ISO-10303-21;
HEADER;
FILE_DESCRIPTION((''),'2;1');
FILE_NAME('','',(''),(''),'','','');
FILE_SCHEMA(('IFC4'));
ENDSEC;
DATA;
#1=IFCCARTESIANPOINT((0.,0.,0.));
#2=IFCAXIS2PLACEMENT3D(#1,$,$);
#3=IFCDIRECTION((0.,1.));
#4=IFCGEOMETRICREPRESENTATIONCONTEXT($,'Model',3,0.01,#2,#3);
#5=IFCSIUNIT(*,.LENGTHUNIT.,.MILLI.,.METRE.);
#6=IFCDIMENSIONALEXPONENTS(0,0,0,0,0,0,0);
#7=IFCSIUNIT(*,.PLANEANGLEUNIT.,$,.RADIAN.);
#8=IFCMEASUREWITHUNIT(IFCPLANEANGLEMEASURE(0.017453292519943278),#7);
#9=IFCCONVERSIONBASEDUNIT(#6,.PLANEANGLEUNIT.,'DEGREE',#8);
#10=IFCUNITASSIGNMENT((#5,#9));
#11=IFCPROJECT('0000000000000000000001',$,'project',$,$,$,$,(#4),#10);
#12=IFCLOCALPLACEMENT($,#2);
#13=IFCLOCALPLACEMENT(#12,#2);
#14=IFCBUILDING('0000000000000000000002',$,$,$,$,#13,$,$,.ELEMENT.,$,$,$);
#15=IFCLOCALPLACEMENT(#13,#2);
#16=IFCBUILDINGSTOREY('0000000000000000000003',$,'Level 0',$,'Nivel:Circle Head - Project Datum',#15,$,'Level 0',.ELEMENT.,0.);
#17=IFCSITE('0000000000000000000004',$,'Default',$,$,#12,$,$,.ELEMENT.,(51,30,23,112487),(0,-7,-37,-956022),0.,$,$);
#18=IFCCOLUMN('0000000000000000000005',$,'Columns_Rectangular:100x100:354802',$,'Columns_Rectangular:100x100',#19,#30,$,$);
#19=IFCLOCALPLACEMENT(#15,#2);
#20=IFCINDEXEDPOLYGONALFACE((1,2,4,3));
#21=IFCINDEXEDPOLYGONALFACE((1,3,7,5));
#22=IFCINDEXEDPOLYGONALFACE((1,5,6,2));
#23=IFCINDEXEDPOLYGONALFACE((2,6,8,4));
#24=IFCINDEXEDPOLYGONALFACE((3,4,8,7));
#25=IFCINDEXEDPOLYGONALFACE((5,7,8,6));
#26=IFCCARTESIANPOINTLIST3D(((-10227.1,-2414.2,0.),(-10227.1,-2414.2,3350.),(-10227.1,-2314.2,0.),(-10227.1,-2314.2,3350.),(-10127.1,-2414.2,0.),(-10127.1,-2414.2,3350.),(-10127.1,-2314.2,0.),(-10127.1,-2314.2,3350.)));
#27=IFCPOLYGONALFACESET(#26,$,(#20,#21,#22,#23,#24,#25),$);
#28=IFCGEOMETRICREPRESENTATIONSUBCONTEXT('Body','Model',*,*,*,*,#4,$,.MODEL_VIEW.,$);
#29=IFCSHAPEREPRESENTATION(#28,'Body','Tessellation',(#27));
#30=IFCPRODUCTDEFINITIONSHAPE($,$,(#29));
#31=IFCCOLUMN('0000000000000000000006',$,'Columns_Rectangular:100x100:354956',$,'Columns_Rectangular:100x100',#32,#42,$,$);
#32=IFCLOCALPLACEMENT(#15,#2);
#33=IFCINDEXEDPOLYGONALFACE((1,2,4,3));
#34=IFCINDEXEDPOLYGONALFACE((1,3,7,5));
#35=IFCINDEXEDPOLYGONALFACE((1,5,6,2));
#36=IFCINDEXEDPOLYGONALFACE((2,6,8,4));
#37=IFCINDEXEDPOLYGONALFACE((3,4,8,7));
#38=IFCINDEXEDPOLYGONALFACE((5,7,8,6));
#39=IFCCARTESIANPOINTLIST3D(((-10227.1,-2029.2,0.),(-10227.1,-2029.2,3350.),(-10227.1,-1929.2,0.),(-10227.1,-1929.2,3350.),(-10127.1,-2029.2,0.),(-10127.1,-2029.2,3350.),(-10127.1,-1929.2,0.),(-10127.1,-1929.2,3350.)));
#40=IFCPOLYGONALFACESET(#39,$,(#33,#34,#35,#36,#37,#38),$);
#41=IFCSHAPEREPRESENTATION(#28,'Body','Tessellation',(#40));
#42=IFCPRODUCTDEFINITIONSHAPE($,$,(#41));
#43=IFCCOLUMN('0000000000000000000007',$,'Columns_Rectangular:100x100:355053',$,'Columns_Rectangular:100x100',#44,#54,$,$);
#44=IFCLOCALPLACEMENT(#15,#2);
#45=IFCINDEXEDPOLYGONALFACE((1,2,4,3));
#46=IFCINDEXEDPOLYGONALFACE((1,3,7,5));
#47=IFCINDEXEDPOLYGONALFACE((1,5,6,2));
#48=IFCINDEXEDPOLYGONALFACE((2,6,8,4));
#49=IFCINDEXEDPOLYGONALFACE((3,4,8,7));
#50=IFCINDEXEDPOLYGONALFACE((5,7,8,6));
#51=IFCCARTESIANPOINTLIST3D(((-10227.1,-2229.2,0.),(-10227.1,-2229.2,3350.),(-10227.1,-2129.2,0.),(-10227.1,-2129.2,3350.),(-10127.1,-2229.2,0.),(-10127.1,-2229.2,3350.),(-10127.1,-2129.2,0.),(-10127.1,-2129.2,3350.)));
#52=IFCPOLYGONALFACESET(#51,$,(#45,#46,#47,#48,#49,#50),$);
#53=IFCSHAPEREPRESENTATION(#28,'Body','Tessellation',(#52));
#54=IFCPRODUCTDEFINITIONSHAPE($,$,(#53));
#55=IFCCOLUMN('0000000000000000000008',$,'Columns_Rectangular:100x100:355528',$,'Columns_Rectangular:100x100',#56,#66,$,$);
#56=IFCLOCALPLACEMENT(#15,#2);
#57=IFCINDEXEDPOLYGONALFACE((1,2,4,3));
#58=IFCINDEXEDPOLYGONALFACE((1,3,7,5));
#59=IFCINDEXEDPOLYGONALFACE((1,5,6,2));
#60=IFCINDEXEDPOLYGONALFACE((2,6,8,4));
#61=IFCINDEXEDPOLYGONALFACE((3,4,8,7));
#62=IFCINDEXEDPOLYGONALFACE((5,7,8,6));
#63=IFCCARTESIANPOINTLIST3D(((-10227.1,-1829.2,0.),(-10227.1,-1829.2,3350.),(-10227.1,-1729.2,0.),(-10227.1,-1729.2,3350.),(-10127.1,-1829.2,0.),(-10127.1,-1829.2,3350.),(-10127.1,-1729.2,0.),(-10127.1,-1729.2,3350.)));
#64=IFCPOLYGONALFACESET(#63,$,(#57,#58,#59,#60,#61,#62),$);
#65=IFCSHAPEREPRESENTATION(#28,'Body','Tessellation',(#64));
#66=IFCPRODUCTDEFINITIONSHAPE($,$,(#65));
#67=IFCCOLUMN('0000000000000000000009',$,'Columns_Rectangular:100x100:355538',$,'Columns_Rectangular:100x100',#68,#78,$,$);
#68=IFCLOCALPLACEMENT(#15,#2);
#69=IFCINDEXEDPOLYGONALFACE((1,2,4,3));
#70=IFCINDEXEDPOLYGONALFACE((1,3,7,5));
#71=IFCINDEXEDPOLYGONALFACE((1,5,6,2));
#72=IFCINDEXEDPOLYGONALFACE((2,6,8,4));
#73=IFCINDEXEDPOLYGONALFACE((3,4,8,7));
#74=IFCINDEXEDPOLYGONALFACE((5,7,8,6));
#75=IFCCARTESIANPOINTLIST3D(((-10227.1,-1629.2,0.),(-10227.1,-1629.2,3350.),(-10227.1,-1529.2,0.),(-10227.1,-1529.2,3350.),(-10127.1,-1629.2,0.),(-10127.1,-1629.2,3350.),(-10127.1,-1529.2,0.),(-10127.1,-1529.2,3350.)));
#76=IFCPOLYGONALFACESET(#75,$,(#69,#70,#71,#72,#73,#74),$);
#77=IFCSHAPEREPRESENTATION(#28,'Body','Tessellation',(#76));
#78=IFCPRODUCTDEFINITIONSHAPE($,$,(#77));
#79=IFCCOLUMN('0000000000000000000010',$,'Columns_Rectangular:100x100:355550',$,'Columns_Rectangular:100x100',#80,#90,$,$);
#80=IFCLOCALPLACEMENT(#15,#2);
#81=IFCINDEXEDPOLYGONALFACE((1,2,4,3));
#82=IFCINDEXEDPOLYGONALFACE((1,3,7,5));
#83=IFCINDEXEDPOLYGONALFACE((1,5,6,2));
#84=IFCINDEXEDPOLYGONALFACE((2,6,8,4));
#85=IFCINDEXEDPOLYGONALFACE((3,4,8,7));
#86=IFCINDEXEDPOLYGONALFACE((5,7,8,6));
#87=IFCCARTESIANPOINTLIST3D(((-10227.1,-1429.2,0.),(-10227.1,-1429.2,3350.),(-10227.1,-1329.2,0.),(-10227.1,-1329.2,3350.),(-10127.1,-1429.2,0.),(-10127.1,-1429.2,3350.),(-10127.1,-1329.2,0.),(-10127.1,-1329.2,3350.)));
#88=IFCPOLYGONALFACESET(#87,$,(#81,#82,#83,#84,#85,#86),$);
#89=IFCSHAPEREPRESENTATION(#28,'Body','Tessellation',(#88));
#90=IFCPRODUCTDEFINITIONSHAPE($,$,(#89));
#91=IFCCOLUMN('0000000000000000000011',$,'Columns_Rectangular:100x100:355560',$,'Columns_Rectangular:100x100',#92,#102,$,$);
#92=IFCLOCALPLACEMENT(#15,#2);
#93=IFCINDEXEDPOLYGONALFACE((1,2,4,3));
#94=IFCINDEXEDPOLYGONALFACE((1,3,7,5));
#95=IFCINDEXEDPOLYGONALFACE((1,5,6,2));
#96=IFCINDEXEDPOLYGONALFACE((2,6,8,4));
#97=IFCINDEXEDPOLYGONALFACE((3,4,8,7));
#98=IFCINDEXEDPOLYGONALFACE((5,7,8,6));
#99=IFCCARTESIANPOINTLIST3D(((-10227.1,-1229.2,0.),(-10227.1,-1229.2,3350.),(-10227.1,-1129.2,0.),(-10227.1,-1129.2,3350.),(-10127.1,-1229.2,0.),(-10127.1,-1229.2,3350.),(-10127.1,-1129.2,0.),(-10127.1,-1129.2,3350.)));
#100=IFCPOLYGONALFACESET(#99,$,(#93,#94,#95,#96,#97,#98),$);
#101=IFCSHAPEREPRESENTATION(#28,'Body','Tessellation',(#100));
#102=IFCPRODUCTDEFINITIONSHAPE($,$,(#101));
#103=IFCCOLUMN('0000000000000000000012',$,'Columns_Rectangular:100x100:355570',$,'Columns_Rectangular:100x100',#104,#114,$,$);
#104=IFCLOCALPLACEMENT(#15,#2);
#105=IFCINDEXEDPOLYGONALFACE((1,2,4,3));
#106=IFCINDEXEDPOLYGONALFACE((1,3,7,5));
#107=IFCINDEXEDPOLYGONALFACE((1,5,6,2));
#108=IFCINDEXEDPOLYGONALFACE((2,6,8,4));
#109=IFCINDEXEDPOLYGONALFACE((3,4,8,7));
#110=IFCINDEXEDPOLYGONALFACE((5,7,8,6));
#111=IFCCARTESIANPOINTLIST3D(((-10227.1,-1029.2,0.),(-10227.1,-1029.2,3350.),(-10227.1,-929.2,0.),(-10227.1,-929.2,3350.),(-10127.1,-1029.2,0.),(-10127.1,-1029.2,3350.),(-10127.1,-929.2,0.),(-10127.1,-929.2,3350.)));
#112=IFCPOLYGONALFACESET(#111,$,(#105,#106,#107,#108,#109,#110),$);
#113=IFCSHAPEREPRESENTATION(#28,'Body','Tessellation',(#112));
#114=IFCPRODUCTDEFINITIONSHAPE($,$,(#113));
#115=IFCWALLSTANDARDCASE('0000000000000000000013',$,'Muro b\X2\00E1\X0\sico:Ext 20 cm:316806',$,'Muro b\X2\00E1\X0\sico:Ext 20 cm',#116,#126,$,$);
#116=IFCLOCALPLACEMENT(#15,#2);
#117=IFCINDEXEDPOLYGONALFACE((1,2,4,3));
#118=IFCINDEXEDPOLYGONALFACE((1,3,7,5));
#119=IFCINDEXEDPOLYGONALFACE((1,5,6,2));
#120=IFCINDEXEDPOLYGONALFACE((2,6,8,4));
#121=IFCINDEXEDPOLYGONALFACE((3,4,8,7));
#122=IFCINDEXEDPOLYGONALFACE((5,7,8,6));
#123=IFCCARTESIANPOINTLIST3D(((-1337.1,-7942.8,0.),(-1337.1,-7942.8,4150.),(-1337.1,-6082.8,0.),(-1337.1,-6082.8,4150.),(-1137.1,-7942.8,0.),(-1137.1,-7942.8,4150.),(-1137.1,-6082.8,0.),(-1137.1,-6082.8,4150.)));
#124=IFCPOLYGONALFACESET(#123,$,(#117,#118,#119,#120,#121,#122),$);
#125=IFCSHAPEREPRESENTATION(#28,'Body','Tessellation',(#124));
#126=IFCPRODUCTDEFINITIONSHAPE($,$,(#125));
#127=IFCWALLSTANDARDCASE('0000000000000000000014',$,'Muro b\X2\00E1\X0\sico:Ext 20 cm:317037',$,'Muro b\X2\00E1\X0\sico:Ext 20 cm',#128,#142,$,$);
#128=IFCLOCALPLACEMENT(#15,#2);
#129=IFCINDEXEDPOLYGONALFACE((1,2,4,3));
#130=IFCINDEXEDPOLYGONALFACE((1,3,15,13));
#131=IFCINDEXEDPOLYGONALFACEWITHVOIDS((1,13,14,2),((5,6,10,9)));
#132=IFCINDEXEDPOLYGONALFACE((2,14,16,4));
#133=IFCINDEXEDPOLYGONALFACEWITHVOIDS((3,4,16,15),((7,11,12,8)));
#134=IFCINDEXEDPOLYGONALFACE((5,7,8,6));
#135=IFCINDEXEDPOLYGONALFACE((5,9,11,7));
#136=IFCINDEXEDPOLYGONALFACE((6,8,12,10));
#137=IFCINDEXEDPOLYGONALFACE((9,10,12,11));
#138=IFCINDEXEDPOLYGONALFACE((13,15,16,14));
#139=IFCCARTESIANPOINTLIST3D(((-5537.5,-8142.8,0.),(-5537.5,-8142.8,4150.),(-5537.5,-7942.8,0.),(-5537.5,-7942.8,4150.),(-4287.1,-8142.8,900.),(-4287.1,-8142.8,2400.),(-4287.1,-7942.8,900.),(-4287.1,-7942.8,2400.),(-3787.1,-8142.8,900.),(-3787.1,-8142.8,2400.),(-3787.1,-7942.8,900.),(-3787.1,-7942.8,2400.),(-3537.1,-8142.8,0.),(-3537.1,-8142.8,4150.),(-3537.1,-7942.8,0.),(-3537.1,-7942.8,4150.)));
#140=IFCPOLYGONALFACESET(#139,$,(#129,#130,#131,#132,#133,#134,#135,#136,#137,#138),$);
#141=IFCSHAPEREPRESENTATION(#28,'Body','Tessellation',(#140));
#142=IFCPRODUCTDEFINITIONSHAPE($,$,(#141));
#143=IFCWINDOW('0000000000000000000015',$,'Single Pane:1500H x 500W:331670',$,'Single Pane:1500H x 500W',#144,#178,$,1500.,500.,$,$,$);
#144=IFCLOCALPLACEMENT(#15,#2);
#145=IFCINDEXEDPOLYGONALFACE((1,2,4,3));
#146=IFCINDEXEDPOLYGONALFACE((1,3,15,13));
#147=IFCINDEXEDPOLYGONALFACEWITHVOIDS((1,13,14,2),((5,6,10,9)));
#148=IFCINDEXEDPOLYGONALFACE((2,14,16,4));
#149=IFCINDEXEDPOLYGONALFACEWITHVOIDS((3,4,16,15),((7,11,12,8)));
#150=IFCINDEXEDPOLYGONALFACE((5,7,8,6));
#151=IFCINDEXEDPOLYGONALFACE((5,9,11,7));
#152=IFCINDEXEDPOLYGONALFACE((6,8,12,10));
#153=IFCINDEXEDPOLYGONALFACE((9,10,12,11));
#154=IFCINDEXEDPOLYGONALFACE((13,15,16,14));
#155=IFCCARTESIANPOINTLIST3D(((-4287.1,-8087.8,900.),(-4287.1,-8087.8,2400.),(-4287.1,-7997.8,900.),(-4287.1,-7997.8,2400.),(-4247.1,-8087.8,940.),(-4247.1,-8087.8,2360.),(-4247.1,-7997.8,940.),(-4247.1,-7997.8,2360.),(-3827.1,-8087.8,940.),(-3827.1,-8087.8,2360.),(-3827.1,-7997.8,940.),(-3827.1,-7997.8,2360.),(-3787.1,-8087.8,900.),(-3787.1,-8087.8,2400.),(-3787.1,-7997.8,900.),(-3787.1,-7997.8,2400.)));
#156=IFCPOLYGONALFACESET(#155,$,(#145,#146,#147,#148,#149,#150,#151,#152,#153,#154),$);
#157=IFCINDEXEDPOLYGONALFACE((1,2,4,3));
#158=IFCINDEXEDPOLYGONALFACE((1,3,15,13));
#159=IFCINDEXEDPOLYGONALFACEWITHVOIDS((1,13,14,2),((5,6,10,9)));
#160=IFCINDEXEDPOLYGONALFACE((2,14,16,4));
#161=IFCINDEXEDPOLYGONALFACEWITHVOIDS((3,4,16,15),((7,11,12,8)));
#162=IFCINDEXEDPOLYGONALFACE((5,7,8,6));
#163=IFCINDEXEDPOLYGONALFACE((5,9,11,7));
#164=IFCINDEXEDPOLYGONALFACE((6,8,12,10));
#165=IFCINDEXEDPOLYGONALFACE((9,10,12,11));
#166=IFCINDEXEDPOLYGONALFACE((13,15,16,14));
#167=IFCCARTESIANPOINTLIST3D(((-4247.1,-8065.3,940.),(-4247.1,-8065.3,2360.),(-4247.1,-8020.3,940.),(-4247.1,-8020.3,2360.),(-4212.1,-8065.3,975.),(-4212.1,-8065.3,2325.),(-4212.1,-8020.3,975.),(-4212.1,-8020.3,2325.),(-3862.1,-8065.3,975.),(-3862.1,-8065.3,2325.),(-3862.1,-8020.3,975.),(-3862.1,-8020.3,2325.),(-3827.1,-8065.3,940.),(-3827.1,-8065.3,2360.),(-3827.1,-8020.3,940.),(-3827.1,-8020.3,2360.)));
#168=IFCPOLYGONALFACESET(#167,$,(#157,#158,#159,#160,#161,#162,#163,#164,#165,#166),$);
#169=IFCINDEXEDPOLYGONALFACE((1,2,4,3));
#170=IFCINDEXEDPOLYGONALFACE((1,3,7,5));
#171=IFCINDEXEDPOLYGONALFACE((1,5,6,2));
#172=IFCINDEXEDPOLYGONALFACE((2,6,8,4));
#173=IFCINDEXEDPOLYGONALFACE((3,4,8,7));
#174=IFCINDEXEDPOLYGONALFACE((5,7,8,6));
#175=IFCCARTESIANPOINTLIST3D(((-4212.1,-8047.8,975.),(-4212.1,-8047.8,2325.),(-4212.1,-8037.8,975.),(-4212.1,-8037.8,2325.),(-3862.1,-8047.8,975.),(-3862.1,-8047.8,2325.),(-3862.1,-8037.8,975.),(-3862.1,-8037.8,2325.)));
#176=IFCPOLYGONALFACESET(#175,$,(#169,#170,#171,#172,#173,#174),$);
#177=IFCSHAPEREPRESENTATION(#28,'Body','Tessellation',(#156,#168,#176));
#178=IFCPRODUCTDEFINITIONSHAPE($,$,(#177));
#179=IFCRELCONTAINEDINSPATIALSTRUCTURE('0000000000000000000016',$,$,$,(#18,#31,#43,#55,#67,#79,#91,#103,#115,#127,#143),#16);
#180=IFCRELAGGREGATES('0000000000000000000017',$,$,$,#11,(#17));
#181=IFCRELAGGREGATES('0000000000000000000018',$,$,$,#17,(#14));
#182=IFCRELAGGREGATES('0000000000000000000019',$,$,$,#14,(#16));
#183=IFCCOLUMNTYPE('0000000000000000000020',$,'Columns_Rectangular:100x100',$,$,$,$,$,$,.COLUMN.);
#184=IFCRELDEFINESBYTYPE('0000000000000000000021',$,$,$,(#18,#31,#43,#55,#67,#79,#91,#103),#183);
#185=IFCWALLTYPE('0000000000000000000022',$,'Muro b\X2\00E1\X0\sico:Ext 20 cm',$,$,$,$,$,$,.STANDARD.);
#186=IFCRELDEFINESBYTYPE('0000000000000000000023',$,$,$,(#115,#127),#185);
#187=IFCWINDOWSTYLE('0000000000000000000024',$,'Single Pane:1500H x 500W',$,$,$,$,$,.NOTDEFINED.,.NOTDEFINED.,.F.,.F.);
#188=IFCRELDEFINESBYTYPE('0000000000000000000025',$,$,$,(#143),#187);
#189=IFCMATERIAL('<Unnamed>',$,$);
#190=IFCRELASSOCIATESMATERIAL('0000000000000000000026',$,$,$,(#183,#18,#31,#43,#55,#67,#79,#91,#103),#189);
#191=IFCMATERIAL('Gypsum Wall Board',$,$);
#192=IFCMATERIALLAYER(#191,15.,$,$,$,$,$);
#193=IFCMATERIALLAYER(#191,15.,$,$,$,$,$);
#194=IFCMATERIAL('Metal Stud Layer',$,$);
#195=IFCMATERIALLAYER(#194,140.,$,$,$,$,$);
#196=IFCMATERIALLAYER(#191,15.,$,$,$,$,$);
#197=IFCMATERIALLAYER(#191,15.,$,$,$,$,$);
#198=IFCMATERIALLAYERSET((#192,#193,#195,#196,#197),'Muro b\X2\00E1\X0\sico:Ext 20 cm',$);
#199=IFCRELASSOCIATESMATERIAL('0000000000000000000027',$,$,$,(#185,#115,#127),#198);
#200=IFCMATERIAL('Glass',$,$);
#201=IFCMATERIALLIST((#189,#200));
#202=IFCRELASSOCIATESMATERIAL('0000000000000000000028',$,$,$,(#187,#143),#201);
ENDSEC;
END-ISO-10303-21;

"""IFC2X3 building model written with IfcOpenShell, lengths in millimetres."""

from ifc_helpers import new_model, entity, si_unit, converted_unit, direction, frame, frame_2d, origin, origin_2d_with_axis, place, context, subcontext, project, spatial, polyline, rectangle, outline, extrude, source, transform, mapped, material, material_list, layer, layer_set, layer_usage, type_object, type_shapes, element, fill, save


model = new_model("IFC2X3")

# Units and contexts
model_context = context("Model", 3, precision=0.01, world=origin(), true_north=direction((0.0, 1.0)))
body_context = subcontext(model_context, "Body", "Model", "MODEL_VIEW")
ifc_project = project(units=[si_unit("LENGTHUNIT", "METRE", prefix="MILLI"), converted_unit("PLANEANGLEUNIT", "DEGREE", entity("IfcPlaneAngleMeasure", 0.017453292519943278), si_unit("PLANEANGLEUNIT", "RADIAN"), dimensions=[0, 0, 0, 0, 0, 0, 0])], contexts=[model_context])

# Site, building, storey
site_placement = place(None, origin())
site = spatial("IfcSite", under=ifc_project, at=site_placement, Name="Default", CompositionType="ELEMENT", RefLatitude=(51, 30, 23, 112487), RefLongitude=(0, -7, -37, -956022), RefElevation=0.0)
building_placement = place(site_placement, origin())
building = spatial("IfcBuilding", under=site, at=building_placement, CompositionType="ELEMENT")
storey_placement = place(building_placement, origin())
storey = spatial("IfcBuildingStorey", under=building, at=storey_placement, Name="Level 0", ObjectType="Nivel:Circle Head - Project Datum", LongName="Level 0", CompositionType="ELEMENT", Elevation=0.0)

# Columns
ifc_material_1 = material(Name="<Unnamed>")
column_type = type_object("IfcColumnType", Name="Columns_Rectangular:100x100", PredefinedType="COLUMN", material=ifc_material_1)
shared_shape_1 = source(origin(), body_context, "Body", "SweptSolid", [
    extrude(rectangle(XDim=100.0, YDim=100.0, at=origin_2d_with_axis()), frame((0.0, 0.0, 0.0), z_axis=(0.0, 0.0, 1.0), x_axis=(-1.0, 0.0, 0.0)), (0.0, 0.0, 1.0), 3350.0),
])
type_shapes(column_type, [shared_shape_1])
for number, where, name in (
    (1, (-10177.1, -2364.2, 0.0), "Columns_Rectangular:100x100:354802"),
    (2, (-10177.1, -1979.2, 0.0), "Columns_Rectangular:100x100:354956"),
    (3, (-10177.1, -2179.2, 0.0), "Columns_Rectangular:100x100:355053"),
    (4, (-10177.1, -1779.2, 0.0), "Columns_Rectangular:100x100:355528"),
    (5, (-10177.1, -1579.2, 0.0), "Columns_Rectangular:100x100:355538"),
    (6, (-10177.1, -1379.2, 0.0), "Columns_Rectangular:100x100:355550"),
    (7, (-10177.1, -1179.2, 0.0), "Columns_Rectangular:100x100:355560"),
    (8, (-10177.1, -979.2, 0.0), "Columns_Rectangular:100x100:355570"),
):
    element("IfcColumn", number, at=place(storey_placement, frame(where)), inside=storey, type_object=column_type, material=ifc_material_1, Name=name, ObjectType="Columns_Rectangular:100x100", context=body_context, shape_type="MappedRepresentation", body=[
        mapped(shared_shape_1, transform((0.0, 0.0, 0.0), scale=1.0)),
    ])

# Wall
ifc_material_2 = material(Name="Gypsum Wall Board")
ifc_layer_1 = layer(ifc_material_2, 15.0)
ifc_layer_2 = layer(ifc_material_2, 15.0)
ifc_material_3 = material(Name="Metal Stud Layer")
ifc_layer_3 = layer(ifc_material_3, 140.0)
ifc_layer_4 = layer(ifc_material_2, 15.0)
ifc_layer_5 = layer(ifc_material_2, 15.0)
ifc_layer_set_1 = layer_set([ifc_layer_1, ifc_layer_2, ifc_layer_3, ifc_layer_4, ifc_layer_5], Name="Muro básico:Ext 20 cm")
ifc_layer_usage_1 = layer_usage(ifc_layer_set_1, "AXIS2", "NEGATIVE", 100.0)
wall_type_1 = type_object("IfcWallType", Name="Muro básico:Ext 20 cm", PredefinedType="STANDARD", material=ifc_layer_set_1)
wall_1_placement = place(storey_placement, frame((-1237.1, -7942.8, 0.0), z_axis=(0.0, 0.0, 1.0), x_axis=(0.0, 1.0, 0.0)))
element("IfcWallStandardCase", 9, at=wall_1_placement, inside=storey, type_object=wall_type_1, material=ifc_layer_usage_1, Name="Muro básico:Ext 20 cm:316806", ObjectType="Muro básico:Ext 20 cm", context=body_context, shape_type="SweptSolid", body=[
    extrude(rectangle(XDim=1860.0, YDim=200.0, at=frame_2d((930.0, 0.0), x_axis=(-1.0, 0.0))), origin(), (0.0, 0.0, 1.0), 4150.0),
])

# Wall, opening, window
ifc_layer_usage_2 = layer_usage(ifc_layer_set_1, "AXIS2", "NEGATIVE", 100.0)
wall_2_placement = place(storey_placement, frame((-3537.1, -8042.8, 0.0), z_axis=(0.0, 0.0, 1.0), x_axis=(-1.0, 0.0, 0.0)))
wall_2 = element("IfcWallStandardCase", 10, at=wall_2_placement, inside=storey, type_object=wall_type_1, material=ifc_layer_usage_2, Name="Muro básico:Ext 20 cm:317037", ObjectType="Muro básico:Ext 20 cm", context=body_context, shape_type="SweptSolid", body=[
    extrude(rectangle(XDim=2000.3, YDim=200.0, at=frame_2d((1000.2, 0.0), x_axis=(-1.0, 0.0))), origin(), (0.0, 0.0, 1.0), 4150.0),
])
opening_1_placement = place(wall_2_placement, frame((750.0, 100.0, 900.0)))
opening_1 = element("IfcOpeningElement", 11, at=opening_1_placement, cuts=wall_2, ObjectType="Opening", context=body_context, shape_type="SweptSolid", body=[
    extrude(rectangle(XDim=1500.0, YDim=500.0, at=frame_2d((750.0, 250.0), x_axis=(1.0, 0.0))), frame((0.0, 0.0, 0.0), z_axis=(0.0, -1.0, 0.0), x_axis=(0.0, 0.0, 1.0)), (0.0, 0.0, 1.0), 200.0),
])
ifc_material_4 = material(Name="Glass")
ifc_material_list = material_list([ifc_material_1, ifc_material_4])
window_style_1 = type_object("IfcWindowStyle", Name="Single Pane:1500H x 500W", ConstructionType="NOTDEFINED", OperationType="NOTDEFINED", ParameterTakesPrecedence=False, Sizeable=False, material=ifc_material_list)
shared_shape_2 = source(origin(), body_context, "Body", "SweptSolid", [
    extrude(outline(polyline([(-250.0, -750.0), (250.0, -750.0), (250.0, 750.0), (-250.0, 750.0), (-250.0, -750.0)]), holes=[polyline([(-210.0, -710.0), (-210.0, 710.0), (210.0, 710.0), (210.0, -710.0), (-210.0, -710.0)])]), frame((250.0, 55.0, 750.0), z_axis=(0.0, 1.0, 0.0), x_axis=(1.0, 0.0, 0.0)), (0.0, 0.0, 1.0), 90.0),
    extrude(outline(polyline([(-210.0, -710.0), (210.0, -710.0), (210.0, 710.0), (-210.0, 710.0), (-210.0, -710.0)]), holes=[polyline([(-175.0, -675.0), (-175.0, 675.0), (175.0, 675.0), (175.0, -675.0), (-175.0, -675.0)])]), frame((250.0, 77.5, 750.0), z_axis=(0.0, 1.0, 0.0), x_axis=(1.0, 0.0, 0.0)), (0.0, 0.0, 1.0), 45.0),
    extrude(rectangle(XDim=10.0, YDim=350.0, at=origin_2d_with_axis()), frame((250.0, 100.0, 75.0), z_axis=(0.0, 0.0, 1.0), x_axis=(0.0, 1.0, 0.0)), (0.0, 0.0, 1.0), 1350.0),
])
type_shapes(window_style_1, [shared_shape_2])
window_1_placement = place(opening_1_placement, frame((0.0, 0.0, 0.0), z_axis=(0.0, 0.0, 1.0), x_axis=(-1.0, 0.0, 0.0)))
window_1 = element("IfcWindow", 12, at=window_1_placement, inside=storey, type_object=window_style_1, material=ifc_material_list, Name="Single Pane:1500H x 500W:331670", ObjectType="Single Pane:1500H x 500W", OverallHeight=1500.0, OverallWidth=500.0, context=body_context, shape_type="MappedRepresentation", body=[
    mapped(shared_shape_2, transform((0.0, 0.0, 0.0), scale=1.0)),
])
fill(opening_1, window_1)

save(model, "model.ifc")
